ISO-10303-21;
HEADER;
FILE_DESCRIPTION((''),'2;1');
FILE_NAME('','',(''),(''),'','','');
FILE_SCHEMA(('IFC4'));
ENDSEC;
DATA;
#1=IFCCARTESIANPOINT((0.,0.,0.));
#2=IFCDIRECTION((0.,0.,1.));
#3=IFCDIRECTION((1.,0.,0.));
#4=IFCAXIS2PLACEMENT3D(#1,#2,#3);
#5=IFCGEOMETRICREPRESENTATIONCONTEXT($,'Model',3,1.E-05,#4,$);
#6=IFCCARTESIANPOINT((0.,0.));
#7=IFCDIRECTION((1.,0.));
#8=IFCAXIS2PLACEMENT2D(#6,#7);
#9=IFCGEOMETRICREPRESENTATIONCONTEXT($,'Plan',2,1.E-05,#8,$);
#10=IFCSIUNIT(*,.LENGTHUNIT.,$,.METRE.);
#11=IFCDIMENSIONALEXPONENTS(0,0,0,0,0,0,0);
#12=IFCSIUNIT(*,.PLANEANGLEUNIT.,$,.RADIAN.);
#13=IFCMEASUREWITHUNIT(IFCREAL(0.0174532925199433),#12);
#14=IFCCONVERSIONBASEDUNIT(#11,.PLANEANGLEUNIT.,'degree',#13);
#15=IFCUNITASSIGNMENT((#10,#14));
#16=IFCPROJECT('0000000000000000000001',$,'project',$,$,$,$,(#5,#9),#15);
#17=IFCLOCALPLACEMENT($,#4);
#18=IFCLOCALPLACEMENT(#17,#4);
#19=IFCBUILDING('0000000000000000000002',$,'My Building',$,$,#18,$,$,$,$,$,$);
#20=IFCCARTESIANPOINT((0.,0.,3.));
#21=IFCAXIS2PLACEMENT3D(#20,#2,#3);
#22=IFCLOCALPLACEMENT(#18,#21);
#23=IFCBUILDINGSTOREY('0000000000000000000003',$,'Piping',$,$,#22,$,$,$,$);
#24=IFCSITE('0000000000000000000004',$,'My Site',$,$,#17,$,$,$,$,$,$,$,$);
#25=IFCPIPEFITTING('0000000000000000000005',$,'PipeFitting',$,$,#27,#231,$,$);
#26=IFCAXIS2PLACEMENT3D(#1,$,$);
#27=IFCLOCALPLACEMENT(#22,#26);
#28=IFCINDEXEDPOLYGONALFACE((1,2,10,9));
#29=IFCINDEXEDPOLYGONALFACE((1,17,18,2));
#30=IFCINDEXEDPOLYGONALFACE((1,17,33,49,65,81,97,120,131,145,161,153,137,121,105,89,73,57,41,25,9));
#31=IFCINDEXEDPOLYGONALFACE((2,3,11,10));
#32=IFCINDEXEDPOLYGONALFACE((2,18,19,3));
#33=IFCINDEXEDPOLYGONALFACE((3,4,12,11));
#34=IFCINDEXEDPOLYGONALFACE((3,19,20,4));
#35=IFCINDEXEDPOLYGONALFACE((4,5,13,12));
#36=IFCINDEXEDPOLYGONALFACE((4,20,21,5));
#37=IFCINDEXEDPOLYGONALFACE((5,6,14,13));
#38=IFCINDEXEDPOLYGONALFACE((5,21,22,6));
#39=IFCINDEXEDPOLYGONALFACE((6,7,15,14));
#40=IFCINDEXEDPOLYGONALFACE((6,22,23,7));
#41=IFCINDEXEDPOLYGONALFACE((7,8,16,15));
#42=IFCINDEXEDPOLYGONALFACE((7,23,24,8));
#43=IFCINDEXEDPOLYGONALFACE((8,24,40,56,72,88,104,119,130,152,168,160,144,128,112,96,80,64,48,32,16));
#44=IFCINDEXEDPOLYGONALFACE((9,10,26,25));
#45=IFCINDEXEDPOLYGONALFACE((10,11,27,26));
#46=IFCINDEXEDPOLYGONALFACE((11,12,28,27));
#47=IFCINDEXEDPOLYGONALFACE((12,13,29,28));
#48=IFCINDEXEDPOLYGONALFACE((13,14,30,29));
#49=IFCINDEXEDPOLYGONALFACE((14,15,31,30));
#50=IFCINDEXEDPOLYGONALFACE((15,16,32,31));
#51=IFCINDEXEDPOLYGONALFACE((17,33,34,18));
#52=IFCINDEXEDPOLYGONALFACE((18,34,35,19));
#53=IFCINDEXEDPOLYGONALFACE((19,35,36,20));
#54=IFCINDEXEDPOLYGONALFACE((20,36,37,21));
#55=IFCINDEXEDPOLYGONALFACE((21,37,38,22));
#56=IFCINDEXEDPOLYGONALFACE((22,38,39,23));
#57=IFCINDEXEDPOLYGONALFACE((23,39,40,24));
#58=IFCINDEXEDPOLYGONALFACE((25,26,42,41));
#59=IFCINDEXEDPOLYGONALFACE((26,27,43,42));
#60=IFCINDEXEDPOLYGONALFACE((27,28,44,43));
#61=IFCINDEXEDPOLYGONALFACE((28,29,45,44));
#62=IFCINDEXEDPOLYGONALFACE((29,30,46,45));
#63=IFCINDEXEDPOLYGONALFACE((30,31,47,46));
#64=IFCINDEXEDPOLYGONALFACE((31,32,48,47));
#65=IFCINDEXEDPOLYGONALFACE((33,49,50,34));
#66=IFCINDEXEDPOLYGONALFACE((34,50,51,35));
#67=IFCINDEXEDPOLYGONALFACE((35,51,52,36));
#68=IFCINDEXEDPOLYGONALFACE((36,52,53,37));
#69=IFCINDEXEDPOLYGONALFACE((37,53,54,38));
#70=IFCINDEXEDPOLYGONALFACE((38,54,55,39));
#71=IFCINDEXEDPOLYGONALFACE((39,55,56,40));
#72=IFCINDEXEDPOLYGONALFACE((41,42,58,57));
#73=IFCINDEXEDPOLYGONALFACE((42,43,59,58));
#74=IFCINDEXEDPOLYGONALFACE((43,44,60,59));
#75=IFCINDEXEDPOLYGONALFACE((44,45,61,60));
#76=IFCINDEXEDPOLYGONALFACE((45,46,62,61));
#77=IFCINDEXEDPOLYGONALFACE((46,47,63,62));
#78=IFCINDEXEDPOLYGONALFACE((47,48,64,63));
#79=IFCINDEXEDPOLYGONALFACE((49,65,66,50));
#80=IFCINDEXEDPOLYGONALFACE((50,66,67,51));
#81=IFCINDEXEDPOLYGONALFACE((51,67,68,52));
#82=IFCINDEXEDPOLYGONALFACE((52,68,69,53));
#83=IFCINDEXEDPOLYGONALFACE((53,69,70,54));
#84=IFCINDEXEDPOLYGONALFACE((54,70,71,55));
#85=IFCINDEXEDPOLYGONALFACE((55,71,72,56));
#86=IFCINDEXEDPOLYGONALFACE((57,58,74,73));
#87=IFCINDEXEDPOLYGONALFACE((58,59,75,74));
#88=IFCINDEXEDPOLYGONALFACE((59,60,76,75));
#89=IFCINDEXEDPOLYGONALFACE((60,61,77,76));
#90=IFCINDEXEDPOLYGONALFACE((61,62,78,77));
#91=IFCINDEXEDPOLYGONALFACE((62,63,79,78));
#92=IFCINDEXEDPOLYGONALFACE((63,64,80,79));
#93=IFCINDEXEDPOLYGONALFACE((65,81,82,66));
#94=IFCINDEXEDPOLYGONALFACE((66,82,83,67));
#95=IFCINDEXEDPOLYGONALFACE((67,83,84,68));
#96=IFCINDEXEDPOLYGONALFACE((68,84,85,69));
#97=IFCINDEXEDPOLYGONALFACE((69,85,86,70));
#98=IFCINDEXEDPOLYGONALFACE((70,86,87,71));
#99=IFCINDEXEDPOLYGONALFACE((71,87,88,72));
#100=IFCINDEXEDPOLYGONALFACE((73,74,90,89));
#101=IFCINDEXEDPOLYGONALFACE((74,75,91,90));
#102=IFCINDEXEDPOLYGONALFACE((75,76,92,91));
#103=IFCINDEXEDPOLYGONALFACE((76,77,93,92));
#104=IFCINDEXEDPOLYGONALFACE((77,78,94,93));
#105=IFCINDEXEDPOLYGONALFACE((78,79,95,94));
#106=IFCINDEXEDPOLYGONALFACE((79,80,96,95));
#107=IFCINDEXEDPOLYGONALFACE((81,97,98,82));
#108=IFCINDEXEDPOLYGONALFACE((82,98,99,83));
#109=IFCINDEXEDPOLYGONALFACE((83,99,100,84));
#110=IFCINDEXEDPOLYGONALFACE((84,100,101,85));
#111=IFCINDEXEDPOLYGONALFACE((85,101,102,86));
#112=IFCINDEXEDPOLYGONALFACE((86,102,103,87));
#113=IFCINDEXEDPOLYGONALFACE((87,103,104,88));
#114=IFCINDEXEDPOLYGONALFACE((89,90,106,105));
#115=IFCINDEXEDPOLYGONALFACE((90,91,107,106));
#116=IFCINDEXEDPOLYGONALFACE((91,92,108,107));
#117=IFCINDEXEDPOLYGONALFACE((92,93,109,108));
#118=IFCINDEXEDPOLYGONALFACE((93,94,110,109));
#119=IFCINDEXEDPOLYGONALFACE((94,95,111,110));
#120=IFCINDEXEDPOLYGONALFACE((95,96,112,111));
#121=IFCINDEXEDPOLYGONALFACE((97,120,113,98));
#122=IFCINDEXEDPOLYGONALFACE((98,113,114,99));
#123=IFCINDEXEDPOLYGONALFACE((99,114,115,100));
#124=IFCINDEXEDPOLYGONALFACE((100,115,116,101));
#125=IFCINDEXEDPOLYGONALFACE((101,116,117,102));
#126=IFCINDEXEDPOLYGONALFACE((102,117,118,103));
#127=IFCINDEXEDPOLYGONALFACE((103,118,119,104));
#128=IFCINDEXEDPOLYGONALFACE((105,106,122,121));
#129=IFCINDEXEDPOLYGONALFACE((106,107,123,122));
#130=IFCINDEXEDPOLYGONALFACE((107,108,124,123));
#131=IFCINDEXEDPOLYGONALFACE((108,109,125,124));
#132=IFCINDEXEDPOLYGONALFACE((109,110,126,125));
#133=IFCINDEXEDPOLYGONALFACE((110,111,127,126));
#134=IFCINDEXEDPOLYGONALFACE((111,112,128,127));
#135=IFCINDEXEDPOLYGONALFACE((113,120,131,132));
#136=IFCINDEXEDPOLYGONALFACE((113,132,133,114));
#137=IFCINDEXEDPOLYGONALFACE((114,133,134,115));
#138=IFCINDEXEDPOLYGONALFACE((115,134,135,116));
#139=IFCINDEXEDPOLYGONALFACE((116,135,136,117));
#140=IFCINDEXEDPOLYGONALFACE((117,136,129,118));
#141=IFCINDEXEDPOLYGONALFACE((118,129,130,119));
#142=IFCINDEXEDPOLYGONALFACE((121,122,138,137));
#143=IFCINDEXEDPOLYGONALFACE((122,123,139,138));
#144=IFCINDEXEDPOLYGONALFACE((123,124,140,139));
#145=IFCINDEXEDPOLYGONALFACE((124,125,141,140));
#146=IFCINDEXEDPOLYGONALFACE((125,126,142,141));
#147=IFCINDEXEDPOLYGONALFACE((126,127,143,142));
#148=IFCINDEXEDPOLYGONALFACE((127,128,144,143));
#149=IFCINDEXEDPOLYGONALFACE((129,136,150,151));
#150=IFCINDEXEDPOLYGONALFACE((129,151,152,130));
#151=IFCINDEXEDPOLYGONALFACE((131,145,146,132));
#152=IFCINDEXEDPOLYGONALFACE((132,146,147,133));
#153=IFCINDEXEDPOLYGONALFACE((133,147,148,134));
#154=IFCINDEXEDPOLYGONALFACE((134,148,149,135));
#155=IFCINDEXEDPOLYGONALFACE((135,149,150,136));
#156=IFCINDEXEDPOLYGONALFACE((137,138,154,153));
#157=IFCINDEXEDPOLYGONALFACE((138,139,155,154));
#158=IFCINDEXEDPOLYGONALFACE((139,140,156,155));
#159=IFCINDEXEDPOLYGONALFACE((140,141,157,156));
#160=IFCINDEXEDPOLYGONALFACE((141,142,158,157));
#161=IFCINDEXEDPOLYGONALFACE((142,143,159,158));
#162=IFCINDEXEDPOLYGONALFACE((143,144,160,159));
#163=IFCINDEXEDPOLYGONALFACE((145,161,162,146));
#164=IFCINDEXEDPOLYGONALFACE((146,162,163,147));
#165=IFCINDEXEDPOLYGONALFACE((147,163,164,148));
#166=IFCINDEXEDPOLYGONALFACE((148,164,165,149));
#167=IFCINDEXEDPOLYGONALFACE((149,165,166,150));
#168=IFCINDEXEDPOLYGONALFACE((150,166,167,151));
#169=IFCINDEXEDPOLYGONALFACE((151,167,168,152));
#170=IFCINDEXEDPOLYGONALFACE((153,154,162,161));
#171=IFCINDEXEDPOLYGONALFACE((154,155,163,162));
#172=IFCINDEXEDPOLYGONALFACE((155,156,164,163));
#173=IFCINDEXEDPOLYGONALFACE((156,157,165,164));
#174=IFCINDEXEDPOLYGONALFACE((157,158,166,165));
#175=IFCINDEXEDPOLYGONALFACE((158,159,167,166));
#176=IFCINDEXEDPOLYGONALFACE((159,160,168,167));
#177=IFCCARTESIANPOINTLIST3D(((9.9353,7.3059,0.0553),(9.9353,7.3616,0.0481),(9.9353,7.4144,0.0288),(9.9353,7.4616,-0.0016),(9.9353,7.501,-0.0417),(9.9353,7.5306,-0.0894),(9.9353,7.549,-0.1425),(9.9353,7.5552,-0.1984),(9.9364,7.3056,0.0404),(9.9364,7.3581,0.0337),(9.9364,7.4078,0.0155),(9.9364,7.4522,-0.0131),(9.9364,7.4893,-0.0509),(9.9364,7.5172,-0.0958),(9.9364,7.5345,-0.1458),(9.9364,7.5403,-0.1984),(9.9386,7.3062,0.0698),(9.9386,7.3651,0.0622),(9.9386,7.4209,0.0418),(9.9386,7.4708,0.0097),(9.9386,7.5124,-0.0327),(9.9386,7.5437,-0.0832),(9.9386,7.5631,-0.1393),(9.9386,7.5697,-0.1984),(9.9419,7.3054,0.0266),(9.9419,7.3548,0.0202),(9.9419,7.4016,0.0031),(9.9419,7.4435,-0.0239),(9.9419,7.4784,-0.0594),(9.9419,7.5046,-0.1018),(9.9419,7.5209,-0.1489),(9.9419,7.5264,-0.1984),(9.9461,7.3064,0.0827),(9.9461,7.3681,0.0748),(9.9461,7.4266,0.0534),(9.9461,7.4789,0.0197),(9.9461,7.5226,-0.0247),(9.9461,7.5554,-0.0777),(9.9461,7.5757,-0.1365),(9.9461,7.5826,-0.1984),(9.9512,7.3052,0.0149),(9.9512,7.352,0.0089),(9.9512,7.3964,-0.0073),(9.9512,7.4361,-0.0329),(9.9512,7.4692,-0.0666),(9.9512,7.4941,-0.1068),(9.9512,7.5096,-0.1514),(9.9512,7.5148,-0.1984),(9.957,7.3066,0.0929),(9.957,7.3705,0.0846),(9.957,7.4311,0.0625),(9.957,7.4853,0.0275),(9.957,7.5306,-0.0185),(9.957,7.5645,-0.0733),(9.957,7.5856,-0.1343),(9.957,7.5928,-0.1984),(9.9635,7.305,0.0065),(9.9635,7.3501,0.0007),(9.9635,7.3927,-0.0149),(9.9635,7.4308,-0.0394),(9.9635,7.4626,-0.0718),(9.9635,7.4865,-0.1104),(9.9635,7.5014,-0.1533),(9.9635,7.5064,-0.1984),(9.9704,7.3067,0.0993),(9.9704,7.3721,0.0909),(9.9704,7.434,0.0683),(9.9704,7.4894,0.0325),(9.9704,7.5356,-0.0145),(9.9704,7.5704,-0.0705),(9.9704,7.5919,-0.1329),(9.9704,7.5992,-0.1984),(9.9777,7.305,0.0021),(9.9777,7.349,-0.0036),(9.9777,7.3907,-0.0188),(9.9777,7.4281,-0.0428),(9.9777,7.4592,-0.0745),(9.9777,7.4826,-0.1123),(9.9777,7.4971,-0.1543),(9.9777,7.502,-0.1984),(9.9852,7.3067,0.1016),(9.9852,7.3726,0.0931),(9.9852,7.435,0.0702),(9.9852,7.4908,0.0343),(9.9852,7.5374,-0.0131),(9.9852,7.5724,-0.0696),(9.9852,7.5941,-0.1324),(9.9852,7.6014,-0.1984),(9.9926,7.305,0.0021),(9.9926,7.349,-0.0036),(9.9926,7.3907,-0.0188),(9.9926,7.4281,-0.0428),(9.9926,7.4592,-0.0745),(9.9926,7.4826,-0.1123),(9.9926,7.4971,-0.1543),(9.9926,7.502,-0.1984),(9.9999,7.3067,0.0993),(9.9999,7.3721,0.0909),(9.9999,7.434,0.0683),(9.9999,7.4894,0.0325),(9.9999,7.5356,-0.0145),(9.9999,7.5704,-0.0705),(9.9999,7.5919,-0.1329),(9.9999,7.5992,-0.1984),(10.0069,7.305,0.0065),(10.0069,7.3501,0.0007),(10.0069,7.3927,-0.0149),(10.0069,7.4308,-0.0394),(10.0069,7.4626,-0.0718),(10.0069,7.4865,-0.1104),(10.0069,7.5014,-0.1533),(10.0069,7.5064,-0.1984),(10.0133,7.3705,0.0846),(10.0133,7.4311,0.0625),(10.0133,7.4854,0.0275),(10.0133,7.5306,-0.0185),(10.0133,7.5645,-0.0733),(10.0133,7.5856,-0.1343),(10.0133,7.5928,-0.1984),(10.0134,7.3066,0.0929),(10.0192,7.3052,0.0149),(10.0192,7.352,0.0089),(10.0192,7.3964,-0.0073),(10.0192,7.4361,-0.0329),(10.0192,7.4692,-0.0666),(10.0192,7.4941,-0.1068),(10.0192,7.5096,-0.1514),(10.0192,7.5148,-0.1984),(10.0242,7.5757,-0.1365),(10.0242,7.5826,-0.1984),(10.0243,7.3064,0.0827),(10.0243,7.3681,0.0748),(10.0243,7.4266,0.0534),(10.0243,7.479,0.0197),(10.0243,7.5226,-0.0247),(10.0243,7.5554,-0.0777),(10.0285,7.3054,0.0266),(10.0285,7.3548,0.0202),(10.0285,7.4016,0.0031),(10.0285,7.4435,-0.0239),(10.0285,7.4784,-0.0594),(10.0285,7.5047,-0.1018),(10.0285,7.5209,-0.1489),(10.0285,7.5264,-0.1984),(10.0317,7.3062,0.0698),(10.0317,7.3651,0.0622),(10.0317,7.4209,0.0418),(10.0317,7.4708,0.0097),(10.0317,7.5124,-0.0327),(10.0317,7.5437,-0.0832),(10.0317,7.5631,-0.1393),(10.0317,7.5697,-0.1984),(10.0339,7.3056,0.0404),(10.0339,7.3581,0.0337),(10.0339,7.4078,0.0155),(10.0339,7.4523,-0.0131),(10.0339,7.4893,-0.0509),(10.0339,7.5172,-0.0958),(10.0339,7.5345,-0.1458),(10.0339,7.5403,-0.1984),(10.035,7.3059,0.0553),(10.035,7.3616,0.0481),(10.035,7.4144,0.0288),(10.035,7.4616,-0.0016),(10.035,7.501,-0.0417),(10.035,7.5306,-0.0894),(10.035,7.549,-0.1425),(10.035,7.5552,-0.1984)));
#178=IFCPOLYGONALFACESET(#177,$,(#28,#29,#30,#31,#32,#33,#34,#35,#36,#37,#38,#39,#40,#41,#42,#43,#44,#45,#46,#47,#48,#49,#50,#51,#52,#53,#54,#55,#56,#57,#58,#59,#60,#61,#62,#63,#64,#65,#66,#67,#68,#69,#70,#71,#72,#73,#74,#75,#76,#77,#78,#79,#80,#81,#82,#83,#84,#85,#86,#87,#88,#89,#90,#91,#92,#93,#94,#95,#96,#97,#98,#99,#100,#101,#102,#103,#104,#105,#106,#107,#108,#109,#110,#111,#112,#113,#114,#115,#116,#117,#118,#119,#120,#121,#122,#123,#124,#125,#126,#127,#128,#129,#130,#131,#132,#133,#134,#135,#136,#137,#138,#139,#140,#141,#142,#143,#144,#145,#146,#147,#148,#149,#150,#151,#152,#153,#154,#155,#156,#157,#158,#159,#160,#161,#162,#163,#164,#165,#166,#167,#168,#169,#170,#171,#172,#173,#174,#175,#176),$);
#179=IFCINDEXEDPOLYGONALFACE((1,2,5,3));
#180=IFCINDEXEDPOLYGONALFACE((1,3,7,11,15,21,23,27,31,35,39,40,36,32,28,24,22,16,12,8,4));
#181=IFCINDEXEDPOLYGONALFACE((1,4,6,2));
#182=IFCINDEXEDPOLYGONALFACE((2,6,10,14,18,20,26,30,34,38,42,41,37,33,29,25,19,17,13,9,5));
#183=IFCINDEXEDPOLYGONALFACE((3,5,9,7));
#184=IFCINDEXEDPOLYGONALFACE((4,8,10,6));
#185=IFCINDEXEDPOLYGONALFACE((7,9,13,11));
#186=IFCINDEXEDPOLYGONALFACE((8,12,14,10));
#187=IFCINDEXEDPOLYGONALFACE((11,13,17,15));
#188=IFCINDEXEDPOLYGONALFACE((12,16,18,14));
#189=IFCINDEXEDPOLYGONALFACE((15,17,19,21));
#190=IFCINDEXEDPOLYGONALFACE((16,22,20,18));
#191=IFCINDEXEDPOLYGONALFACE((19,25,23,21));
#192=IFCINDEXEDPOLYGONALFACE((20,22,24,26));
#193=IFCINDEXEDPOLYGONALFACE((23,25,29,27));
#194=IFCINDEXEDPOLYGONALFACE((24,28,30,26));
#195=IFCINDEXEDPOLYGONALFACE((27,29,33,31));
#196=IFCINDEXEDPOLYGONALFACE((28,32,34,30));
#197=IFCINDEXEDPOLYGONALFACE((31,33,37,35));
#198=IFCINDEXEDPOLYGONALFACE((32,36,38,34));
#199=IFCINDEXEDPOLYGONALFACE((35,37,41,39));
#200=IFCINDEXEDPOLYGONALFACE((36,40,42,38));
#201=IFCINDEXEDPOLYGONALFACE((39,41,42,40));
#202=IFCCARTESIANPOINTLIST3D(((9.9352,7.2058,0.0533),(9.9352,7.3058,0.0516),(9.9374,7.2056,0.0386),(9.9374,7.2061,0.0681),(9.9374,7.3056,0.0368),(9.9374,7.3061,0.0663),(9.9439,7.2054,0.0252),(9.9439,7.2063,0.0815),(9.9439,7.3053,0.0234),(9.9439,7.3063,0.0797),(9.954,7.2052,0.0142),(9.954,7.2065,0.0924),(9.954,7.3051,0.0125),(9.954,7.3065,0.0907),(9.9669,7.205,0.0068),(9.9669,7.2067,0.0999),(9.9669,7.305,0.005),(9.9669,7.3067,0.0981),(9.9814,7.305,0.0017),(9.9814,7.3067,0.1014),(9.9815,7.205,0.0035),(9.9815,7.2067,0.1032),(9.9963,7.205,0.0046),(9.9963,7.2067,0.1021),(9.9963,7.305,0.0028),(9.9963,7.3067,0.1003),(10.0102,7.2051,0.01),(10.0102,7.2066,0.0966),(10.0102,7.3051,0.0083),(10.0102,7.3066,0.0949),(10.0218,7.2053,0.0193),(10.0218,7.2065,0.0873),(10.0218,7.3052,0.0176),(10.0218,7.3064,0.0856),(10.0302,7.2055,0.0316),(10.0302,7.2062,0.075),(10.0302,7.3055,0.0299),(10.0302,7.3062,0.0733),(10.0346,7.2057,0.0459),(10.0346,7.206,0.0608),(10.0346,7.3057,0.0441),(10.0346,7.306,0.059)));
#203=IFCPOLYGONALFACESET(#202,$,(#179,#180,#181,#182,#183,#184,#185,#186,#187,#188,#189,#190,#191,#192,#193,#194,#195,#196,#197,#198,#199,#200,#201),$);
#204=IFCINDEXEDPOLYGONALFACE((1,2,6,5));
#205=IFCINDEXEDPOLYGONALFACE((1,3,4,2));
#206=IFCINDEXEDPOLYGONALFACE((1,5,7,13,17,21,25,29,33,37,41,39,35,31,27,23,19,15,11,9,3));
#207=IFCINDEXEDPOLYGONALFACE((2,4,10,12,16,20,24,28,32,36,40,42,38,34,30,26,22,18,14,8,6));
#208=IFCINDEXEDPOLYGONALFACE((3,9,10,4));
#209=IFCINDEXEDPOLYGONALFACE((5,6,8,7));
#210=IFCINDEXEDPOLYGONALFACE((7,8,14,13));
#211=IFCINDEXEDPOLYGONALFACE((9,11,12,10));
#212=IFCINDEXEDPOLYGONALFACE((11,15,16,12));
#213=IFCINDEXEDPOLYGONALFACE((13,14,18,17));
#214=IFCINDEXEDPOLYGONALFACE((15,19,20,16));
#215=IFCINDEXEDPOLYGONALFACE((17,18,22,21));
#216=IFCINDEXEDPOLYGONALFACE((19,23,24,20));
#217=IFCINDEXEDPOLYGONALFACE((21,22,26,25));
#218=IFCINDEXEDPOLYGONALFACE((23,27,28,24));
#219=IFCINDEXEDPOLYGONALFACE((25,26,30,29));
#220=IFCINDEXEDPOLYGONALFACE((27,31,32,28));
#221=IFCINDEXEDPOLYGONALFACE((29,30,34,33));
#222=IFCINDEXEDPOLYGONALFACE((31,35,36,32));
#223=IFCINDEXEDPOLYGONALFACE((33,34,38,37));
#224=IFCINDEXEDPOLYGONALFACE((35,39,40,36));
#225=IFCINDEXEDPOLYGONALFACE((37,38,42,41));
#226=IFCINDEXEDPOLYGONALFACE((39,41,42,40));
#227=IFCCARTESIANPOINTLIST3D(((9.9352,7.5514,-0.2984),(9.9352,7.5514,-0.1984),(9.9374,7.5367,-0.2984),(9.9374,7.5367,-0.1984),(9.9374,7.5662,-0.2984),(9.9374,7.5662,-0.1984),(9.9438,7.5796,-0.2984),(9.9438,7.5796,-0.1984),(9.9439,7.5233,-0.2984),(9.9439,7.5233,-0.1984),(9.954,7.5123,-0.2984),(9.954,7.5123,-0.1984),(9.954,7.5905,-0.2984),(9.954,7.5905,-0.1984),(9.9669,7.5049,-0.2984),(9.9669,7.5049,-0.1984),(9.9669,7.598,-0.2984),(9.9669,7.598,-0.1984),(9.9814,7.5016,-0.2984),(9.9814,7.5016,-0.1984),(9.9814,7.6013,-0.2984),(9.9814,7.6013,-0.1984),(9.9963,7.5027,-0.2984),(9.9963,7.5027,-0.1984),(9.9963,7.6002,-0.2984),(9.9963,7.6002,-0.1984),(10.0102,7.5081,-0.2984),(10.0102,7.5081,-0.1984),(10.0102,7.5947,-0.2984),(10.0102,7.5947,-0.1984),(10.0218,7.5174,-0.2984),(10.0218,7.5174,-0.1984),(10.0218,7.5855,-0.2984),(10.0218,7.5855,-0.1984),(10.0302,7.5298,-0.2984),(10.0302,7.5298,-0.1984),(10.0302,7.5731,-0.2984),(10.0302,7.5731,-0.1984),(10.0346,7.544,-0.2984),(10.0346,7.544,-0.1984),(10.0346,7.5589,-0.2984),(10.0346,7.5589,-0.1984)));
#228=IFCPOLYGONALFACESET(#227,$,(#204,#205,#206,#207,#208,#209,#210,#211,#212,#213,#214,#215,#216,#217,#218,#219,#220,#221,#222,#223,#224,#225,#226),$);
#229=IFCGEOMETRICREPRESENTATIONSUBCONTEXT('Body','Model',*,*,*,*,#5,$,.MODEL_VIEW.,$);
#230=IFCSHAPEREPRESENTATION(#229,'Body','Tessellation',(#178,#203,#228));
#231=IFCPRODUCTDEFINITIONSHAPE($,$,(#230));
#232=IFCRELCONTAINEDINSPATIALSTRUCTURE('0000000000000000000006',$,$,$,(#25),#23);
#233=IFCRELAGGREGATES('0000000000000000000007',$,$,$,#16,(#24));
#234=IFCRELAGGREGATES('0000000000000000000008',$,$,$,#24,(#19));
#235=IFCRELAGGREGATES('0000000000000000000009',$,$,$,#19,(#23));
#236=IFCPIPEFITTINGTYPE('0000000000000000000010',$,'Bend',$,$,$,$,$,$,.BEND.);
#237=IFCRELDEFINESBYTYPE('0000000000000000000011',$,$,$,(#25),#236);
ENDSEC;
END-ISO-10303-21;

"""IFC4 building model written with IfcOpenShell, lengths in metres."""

from ifc_helpers import new_model, entity, si_unit, converted_unit, frame, origin_with_axes, origin_2d_with_axis, place, context, subcontext, project, spatial, circle, extrude, source, transform, mapped, type_object, type_shapes, element, save


model = new_model("IFC4")

# Units and contexts
model_context = context("Model", 3, precision=1e-05, world=origin_with_axes())
plan_context = context("Plan", 2, precision=1e-05, world=origin_2d_with_axis())
body_context = subcontext(model_context, "Body", "Model", "MODEL_VIEW")
ifc_project = project(units=[si_unit("LENGTHUNIT", "METRE"), converted_unit("PLANEANGLEUNIT", "degree", entity("IfcReal", 0.0174532925199433), si_unit("PLANEANGLEUNIT", "RADIAN"), dimensions=[0, 0, 0, 0, 0, 0, 0])], contexts=[model_context, plan_context])

# Site, building, storey
site_placement = place(None, origin_with_axes())
site = spatial("IfcSite", under=ifc_project, at=site_placement, Name="My Site")
building_placement = place(site_placement, origin_with_axes())
building = spatial("IfcBuilding", under=site, at=building_placement, Name="My Building")
storey_placement = place(building_placement, frame((0.0, 0.0, 3.0), z_axis=(0.0, 0.0, 1.0), x_axis=(1.0, 0.0, 0.0)))
storey = spatial("IfcBuildingStorey", under=building, at=storey_placement, Name="Piping")

# Pipe fitting
pipe_fitting_type_1 = type_object("IfcPipeFittingType", Name="Bend", PredefinedType="BEND")
shared_shape_1 = source(origin_with_axes(), body_context, "Body", "SolidModel", [
    entity("IfcSweptDiskSolid", entity("IfcIndexedPolyCurve", entity("IfcCartesianPointList3D", [[0.0, 0.0, 0.1], [0.0, -0.0717, 0.2752], [0.0, -0.2456, 0.35]]), [entity("IfcArcIndex", [1, 2, 3])]), 0.05),
    extrude(circle(Radius=0.05), origin_with_axes(), (0.0, 0.0, 1.0), 0.1),
    extrude(circle(Radius=0.05), frame((0.0, -0.2456, 0.35), z_axis=(0.0, -0.999846, 0.017575), x_axis=(1.0, 0.0, 0.0)), (0.0, 0.0, 1.0), 0.1),
])
type_shapes(pipe_fitting_type_1, [shared_shape_1])
for number, where, z_axis, x_axis, name in (
    (1, (9.9852, 7.2059, 0.0533), (-0.000099, 0.999846, -0.017575), (-1.0, -0.000099, 0.0), "PipeFitting"),
):
    element("IfcPipeFitting", number, at=place(storey_placement, frame(where, z_axis=z_axis, x_axis=x_axis)), inside=storey, type_object=pipe_fitting_type_1, Name=name, context=body_context, shape_type="MappedRepresentation", body=[
        mapped(shared_shape_1, transform((0.0, 0.0, 0.0), x_axis=(1.0, 0.0, 0.0), y_axis=(0.0, 1.0, 0.0), z_axis=(0.0, 0.0, 1.0), scale=1.0)),
    ])

save(model, "model.ifc")
